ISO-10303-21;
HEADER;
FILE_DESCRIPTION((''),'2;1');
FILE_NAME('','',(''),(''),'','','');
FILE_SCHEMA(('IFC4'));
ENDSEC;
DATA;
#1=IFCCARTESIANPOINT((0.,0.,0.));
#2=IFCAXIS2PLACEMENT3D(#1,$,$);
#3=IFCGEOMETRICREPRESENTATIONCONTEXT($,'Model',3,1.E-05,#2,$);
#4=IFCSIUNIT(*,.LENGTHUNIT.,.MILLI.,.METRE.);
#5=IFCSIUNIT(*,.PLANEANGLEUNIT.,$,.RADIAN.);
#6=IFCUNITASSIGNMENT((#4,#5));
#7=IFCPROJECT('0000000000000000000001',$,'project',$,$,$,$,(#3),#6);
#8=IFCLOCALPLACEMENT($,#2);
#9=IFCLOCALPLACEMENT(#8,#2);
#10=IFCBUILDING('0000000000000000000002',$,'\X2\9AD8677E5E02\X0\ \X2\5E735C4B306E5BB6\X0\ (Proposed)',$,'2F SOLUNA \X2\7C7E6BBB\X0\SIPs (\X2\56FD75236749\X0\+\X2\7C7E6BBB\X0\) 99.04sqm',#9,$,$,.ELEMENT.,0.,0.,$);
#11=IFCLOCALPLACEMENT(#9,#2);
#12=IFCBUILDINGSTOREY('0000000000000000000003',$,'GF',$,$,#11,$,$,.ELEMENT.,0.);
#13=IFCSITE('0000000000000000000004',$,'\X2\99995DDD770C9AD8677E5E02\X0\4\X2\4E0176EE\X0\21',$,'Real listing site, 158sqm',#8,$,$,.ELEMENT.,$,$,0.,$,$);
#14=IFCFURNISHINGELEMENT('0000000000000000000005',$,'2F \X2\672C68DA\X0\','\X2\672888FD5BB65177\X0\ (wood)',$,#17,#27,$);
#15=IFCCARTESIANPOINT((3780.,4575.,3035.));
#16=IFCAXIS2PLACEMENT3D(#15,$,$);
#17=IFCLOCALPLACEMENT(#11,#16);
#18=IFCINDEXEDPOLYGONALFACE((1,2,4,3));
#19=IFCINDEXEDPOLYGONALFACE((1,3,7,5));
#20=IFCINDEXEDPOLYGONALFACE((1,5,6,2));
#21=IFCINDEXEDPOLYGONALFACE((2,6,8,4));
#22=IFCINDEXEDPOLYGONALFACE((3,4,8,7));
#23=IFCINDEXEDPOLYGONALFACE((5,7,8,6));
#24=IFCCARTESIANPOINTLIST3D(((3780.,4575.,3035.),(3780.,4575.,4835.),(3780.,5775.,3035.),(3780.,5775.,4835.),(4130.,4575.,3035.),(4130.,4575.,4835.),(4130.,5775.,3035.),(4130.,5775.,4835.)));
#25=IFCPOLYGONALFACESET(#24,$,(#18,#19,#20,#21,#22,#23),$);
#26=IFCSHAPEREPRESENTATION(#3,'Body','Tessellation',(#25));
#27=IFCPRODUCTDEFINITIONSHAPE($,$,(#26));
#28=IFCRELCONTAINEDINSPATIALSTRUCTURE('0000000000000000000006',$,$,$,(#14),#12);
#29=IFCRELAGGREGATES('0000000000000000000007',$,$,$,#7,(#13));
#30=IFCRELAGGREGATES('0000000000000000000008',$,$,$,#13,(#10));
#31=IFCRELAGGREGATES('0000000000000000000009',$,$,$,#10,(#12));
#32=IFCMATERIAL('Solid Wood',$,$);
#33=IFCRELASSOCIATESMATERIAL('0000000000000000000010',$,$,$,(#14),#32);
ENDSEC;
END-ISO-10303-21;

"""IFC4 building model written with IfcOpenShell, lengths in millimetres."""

from ifc_helpers import new_model, si_unit, frame, frame_2d, origin, place, context, project, spatial, rectangle, extrude, material, element, save


model = new_model("IFC4")

# Units and contexts
model_context = context("Model", 3, precision=1e-05, world=origin())
ifc_project = project(units=[si_unit("LENGTHUNIT", "METRE", prefix="MILLI"), si_unit("PLANEANGLEUNIT", "RADIAN")], contexts=[model_context])

# Site, building, storey
site_placement = place(None, origin())
site = spatial("IfcSite", under=ifc_project, at=site_placement, Name="香川県高松市4丁目21", ObjectType="Real listing site, 158sqm", CompositionType="ELEMENT", RefElevation=0.0)
building_placement = place(site_placement, origin())
building = spatial("IfcBuilding", under=site, at=building_placement, Name="高松市 平屋の家 (Proposed)", ObjectType="2F SOLUNA 籾殻SIPs (国産杉+籾殻) 99.04sqm", CompositionType="ELEMENT", ElevationOfRefHeight=0.0, ElevationOfTerrain=0.0)
storey_placement = place(building_placement, origin())
storey = spatial("IfcBuildingStorey", under=building, at=storey_placement, Name="GF", CompositionType="ELEMENT", Elevation=0.0)

# Shared definitions
ifc_material_1 = material(Name="Solid Wood")

# Furnishing element
furnishing_placement = place(storey_placement, frame((3780.0, 4575.0, 3035.0)))
element("IfcFurnishingElement", 1, at=furnishing_placement, inside=storey, material=ifc_material_1, Name="2F 本棚", Description="木製家具 (wood)", context=model_context, shape_type="SweptSolid", body=[
    extrude(rectangle(XDim=350.0, YDim=1200.0, at=frame_2d((175.0, 600.0))), frame((3780.0, 4575.0, 3035.0)), (0.0, 0.0, 1.0), 1800.0),
])

save(model, "model.ifc")
